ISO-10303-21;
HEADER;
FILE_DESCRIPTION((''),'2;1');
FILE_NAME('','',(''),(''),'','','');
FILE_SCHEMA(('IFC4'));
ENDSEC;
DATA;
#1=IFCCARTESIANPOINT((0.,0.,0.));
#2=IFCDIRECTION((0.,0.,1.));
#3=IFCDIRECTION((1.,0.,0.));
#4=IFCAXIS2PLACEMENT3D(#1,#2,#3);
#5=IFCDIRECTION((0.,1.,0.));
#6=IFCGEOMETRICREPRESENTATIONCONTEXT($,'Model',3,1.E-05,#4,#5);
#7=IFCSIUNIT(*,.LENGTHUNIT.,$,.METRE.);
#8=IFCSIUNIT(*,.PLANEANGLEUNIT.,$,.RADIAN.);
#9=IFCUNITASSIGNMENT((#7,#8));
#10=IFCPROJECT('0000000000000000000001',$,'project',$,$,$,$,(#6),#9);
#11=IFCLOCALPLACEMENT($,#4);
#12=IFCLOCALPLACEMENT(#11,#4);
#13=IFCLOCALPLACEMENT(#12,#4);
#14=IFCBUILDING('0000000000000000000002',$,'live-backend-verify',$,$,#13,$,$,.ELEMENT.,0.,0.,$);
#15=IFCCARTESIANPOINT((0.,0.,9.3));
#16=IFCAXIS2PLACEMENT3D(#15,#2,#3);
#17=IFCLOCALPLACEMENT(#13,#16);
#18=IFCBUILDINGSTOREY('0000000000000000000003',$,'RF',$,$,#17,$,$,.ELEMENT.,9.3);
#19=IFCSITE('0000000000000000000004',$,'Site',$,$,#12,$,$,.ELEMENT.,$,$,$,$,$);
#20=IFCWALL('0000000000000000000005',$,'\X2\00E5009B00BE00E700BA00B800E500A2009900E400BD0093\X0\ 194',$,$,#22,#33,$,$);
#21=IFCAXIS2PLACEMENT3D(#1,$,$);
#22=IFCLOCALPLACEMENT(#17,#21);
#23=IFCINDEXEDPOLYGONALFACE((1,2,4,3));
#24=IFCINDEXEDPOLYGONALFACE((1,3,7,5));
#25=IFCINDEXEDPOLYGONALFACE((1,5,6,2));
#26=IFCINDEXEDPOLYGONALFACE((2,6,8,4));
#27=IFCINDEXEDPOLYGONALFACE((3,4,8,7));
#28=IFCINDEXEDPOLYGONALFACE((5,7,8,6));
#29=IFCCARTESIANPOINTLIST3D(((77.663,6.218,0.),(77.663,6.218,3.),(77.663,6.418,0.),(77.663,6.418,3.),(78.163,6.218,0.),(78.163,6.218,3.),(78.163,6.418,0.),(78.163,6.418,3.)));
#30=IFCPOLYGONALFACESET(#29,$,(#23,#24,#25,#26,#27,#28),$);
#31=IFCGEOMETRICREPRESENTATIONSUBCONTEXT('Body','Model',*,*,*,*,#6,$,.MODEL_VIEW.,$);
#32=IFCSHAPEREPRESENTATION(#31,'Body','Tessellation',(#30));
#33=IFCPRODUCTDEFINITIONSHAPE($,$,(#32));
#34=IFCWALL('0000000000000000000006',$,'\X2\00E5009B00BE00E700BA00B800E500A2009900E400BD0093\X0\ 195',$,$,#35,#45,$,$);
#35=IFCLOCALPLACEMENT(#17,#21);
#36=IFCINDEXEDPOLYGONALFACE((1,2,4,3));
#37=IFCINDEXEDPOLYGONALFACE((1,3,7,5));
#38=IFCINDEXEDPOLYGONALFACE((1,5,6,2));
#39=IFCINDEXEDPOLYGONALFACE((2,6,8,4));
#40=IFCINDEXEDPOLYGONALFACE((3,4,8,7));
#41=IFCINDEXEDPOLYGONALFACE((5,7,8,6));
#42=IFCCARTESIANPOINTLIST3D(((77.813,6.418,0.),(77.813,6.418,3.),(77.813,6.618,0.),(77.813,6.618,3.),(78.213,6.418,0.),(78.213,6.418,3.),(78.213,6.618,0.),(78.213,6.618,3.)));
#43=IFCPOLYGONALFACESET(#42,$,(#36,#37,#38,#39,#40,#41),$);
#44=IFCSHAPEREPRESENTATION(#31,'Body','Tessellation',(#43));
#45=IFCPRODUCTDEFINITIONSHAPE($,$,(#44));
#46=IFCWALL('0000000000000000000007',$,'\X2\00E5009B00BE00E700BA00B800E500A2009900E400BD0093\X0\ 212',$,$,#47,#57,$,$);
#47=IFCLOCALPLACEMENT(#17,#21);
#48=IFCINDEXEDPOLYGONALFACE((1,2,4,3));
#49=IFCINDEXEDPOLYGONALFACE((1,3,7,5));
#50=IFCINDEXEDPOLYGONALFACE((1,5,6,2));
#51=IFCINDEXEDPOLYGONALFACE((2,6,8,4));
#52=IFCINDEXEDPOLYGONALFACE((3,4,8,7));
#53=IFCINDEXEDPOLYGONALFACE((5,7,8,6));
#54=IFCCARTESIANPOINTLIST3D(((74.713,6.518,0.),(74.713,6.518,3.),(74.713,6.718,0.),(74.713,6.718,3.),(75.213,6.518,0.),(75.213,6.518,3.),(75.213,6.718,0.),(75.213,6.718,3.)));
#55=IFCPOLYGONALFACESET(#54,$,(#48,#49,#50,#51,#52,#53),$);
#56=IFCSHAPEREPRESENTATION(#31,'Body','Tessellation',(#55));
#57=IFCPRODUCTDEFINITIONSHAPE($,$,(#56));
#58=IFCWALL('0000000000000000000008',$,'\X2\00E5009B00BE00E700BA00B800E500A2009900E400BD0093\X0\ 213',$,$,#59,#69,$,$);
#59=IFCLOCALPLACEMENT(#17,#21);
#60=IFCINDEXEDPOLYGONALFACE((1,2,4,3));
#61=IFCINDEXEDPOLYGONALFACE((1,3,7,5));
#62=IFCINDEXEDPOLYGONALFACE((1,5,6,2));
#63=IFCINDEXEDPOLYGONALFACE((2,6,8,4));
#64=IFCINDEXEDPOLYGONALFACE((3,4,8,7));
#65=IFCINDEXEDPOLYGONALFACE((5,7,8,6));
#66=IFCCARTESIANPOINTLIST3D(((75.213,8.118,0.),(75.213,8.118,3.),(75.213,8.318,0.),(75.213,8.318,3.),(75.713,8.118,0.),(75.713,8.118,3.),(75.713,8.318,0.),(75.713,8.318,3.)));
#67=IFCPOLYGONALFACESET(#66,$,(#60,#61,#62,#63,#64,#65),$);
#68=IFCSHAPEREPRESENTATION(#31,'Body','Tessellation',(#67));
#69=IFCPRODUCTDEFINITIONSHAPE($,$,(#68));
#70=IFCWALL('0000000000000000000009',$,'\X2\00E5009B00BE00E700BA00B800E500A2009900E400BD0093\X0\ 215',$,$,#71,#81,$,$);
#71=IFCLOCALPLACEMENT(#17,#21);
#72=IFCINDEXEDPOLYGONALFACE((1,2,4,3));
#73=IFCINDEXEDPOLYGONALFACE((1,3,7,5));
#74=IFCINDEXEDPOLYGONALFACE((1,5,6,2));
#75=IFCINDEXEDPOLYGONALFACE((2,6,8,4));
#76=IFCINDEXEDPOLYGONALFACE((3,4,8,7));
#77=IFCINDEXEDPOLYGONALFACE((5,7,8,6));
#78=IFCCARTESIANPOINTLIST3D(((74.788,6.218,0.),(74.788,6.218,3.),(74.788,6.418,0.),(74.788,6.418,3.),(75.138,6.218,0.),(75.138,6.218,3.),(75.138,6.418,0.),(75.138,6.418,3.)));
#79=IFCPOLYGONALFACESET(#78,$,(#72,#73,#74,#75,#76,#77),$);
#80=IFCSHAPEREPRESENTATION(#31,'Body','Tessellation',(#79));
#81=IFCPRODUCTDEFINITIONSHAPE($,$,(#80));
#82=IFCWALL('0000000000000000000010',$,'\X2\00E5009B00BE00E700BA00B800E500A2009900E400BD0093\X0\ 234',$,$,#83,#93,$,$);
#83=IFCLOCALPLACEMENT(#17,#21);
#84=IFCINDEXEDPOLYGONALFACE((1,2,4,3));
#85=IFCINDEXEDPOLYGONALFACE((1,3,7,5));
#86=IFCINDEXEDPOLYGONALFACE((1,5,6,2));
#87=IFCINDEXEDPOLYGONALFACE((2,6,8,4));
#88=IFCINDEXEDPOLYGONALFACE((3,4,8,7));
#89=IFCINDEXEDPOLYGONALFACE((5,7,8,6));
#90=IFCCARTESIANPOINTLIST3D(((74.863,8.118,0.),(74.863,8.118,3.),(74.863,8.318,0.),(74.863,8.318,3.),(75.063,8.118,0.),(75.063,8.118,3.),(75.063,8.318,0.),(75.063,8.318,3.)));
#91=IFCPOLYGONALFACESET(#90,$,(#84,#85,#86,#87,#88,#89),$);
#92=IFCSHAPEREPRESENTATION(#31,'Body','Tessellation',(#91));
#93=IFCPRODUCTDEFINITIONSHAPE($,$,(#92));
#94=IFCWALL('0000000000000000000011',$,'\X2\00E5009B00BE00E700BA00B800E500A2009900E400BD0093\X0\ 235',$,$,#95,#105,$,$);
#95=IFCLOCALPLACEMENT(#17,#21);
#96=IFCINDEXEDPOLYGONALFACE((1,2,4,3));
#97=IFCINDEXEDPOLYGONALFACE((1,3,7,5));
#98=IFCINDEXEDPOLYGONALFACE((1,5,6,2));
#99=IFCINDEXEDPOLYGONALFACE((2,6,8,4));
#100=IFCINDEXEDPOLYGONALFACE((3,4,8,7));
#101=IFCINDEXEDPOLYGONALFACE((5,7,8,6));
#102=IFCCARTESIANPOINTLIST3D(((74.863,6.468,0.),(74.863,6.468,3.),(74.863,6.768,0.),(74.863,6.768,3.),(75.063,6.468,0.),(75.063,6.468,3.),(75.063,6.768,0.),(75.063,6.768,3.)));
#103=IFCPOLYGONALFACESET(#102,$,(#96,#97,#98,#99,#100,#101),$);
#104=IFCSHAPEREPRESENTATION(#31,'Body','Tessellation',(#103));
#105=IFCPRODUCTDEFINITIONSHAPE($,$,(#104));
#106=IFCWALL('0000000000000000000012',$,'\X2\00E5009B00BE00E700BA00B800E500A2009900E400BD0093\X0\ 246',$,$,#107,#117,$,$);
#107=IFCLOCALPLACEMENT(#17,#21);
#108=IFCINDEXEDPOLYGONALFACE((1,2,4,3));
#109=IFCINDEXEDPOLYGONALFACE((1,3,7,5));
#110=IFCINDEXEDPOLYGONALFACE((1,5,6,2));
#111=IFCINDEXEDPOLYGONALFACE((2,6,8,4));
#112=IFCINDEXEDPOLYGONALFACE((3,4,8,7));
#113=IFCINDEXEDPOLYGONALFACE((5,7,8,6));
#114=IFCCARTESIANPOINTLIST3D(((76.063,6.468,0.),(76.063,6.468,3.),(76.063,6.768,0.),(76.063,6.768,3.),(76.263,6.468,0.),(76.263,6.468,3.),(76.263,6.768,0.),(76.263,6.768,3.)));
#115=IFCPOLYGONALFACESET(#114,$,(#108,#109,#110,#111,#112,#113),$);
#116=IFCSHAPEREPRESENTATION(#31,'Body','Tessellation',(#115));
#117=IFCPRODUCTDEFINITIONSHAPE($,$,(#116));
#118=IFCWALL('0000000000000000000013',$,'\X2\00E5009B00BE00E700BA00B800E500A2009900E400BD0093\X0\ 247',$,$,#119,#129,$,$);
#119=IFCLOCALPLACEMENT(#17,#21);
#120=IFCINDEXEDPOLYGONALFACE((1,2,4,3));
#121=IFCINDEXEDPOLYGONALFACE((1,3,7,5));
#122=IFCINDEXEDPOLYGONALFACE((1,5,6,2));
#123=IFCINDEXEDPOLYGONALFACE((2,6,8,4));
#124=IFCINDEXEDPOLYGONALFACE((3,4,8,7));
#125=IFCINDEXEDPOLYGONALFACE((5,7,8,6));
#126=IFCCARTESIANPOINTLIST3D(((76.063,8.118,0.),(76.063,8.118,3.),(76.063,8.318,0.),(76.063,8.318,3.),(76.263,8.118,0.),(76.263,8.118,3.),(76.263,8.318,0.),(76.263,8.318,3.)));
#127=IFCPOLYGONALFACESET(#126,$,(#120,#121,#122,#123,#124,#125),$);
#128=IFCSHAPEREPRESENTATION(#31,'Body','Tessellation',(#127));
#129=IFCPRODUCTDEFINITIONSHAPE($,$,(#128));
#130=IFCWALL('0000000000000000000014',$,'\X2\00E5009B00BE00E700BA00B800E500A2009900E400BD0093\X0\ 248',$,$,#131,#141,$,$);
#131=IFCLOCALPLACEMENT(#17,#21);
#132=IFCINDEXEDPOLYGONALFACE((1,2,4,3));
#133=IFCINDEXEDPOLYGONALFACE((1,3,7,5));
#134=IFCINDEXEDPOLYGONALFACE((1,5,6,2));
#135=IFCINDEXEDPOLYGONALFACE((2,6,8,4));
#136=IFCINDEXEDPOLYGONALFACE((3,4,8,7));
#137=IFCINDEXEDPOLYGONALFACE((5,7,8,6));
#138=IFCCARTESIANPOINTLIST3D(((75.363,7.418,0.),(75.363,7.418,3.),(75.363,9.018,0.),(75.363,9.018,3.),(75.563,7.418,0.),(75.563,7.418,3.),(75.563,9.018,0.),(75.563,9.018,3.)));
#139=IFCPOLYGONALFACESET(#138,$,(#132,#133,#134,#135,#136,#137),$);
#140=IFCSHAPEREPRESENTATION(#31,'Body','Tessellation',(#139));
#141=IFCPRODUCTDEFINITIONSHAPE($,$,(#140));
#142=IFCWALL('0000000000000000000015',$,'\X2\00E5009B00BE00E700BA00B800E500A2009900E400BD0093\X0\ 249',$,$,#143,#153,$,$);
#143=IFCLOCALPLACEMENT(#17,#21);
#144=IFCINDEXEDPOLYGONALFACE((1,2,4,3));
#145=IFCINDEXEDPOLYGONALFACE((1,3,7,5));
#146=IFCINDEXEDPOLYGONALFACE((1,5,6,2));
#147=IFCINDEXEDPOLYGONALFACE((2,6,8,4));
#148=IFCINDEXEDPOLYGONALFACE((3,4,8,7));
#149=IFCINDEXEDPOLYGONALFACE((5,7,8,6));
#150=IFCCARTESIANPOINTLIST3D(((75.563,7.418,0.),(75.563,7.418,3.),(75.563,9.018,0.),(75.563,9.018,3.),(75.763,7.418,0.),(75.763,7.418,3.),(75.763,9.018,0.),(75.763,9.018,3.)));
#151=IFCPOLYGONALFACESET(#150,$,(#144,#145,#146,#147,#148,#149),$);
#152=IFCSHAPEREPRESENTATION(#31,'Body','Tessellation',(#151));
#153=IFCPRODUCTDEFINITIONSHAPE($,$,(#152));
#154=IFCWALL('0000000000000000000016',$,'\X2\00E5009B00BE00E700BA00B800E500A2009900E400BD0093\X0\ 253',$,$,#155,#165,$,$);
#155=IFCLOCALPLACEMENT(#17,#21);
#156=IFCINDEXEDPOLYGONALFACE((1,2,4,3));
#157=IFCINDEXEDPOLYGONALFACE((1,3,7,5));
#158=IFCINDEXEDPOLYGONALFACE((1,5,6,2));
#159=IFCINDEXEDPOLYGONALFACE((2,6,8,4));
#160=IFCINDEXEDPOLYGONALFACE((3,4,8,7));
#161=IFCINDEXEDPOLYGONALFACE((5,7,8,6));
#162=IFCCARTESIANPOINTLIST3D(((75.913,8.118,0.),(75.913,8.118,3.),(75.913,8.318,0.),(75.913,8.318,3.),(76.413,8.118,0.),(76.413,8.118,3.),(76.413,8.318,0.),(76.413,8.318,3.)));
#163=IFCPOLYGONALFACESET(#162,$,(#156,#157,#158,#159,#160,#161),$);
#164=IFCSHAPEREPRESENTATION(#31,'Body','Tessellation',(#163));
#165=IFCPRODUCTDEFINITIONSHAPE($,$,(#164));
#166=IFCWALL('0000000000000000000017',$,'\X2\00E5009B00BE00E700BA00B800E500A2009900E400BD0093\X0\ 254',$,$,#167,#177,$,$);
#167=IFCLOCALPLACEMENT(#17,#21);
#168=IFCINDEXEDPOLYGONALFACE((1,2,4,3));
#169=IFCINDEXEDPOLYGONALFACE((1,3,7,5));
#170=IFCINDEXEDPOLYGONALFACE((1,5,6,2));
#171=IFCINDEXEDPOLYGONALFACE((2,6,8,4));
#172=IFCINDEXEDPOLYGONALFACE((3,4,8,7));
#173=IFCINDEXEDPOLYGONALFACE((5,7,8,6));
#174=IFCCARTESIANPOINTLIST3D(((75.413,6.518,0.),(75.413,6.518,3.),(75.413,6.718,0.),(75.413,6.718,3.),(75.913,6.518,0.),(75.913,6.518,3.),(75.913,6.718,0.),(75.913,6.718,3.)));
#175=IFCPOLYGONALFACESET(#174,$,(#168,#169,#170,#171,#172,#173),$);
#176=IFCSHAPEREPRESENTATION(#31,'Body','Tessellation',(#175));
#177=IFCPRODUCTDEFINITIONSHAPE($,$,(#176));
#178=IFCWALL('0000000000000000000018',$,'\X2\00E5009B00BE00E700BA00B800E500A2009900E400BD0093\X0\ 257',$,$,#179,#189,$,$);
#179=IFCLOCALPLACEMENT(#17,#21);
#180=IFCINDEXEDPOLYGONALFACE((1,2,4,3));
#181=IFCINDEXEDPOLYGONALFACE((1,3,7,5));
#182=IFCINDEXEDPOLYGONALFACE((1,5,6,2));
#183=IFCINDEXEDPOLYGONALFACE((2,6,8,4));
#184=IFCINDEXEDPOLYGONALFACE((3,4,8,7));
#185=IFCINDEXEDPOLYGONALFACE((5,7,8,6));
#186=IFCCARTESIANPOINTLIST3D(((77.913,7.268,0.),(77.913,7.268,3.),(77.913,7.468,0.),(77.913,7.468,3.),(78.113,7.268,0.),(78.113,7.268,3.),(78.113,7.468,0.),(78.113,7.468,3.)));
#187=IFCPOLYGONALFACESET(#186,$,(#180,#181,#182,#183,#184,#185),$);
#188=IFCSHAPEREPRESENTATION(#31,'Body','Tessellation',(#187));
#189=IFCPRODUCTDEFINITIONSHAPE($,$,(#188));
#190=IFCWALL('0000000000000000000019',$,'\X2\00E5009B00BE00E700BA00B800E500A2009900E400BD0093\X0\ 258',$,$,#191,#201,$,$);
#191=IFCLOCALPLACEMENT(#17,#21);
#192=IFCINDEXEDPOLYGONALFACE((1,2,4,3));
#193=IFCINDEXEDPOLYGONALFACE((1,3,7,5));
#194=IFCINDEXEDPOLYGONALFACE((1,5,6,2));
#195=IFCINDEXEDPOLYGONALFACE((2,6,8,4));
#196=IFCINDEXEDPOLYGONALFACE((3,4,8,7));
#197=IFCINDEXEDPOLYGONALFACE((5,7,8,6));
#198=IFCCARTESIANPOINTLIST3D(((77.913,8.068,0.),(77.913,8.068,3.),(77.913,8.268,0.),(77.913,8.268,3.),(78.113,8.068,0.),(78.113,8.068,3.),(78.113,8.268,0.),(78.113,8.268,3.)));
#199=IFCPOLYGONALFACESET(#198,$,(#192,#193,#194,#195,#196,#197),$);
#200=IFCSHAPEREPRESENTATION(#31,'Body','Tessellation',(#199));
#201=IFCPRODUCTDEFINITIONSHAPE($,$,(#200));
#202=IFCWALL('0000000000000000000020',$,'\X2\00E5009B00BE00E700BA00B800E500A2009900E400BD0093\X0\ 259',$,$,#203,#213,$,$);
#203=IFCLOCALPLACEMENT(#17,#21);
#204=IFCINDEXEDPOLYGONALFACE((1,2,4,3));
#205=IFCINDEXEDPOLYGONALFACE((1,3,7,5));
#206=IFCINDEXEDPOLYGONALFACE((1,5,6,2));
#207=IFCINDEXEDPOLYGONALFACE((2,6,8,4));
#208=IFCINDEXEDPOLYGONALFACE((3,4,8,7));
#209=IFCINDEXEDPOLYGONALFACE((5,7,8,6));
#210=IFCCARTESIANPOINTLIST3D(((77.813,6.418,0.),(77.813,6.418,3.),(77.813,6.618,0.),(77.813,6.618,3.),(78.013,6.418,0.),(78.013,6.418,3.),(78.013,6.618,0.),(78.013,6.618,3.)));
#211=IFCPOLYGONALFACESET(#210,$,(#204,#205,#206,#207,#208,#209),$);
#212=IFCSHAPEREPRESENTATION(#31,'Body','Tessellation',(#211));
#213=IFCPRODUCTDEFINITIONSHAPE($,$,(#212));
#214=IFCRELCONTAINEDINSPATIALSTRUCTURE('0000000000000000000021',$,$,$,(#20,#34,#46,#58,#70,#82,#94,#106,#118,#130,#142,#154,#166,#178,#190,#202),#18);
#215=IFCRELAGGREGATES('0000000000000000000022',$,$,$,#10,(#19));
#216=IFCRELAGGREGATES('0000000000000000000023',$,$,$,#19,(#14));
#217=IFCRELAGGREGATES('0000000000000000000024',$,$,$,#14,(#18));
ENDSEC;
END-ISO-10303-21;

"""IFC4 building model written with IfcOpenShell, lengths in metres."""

from ifc_helpers import new_model, si_unit, direction, frame, frame_2d, origin_with_axes, place, context, subcontext, project, spatial, rectangle, extrude, element, save


model = new_model("IFC4")

# Units and contexts
model_context = context("Model", 3, precision=1e-05, world=origin_with_axes(), true_north=direction((0.0, 1.0, 0.0)))
body_context = subcontext(model_context, "Body", "Model", "MODEL_VIEW")
ifc_project = project(units=[si_unit("LENGTHUNIT", "METRE"), si_unit("PLANEANGLEUNIT", "RADIAN")], contexts=[model_context])

# Site, building, storey
placement = place(None, origin_with_axes())
site_placement = place(placement, origin_with_axes())
site = spatial("IfcSite", under=ifc_project, at=site_placement, Name="Site", CompositionType="ELEMENT")
building_placement = place(site_placement, origin_with_axes())
building = spatial("IfcBuilding", under=site, at=building_placement, Name="live-backend-verify", CompositionType="ELEMENT", ElevationOfRefHeight=0.0, ElevationOfTerrain=0.0)
storey_placement = place(building_placement, frame((0.0, 0.0, 9.3), z_axis=(0.0, 0.0, 1.0), x_axis=(1.0, 0.0, 0.0)))
storey = spatial("IfcBuildingStorey", under=building, at=storey_placement, Name="RF", CompositionType="ELEMENT", Elevation=9.3)

# Walls
wall_1_placement = place(storey_placement, frame((77.913, 6.318, 0.0), z_axis=(0.0, 0.0, 1.0), x_axis=(1.0, 0.0, 0.0)))
element("IfcWall", 1, at=wall_1_placement, inside=storey, Name="å\u009b¾çº¸å¢\u0099ä½\u0093 194", context=body_context, shape_type="SweptSolid", body=[
    extrude(rectangle(XDim=0.5, YDim=0.2, at=frame_2d((0.0, 0.0), x_axis=(1.0, 0.0, 0.0))), frame((0.0, 0.0, 0.0), z_axis=(0.0, 0.0, 1.0)), (0.0, 0.0, 1.0), 3.0),
])
wall_2_placement = place(storey_placement, frame((78.013, 6.518, 0.0), z_axis=(0.0, 0.0, 1.0), x_axis=(1.0, 0.0, 0.0)))
element("IfcWall", 2, at=wall_2_placement, inside=storey, Name="å\u009b¾çº¸å¢\u0099ä½\u0093 195", context=body_context, shape_type="SweptSolid", body=[
    extrude(rectangle(XDim=0.4, YDim=0.2, at=frame_2d((0.0, 0.0), x_axis=(1.0, 0.0, 0.0))), frame((0.0, 0.0, 0.0), z_axis=(0.0, 0.0, 1.0)), (0.0, 0.0, 1.0), 3.0),
])
for number, where, z_axis, x_axis, name in (
    (3, (74.963, 6.618, 0.0), (0.0, 0.0, 1.0), (1.0, 0.0, 0.0), "å\u009b¾çº¸å¢\u0099ä½\u0093 212"),
    (4, (75.463, 8.218, 0.0), (0.0, 0.0, 1.0), (-1.0, 0.0, 0.0), "å\u009b¾çº¸å¢\u0099ä½\u0093 213"),
):
    element("IfcWall", number, at=place(storey_placement, frame(where, z_axis=z_axis, x_axis=x_axis)), inside=storey, Name=name, context=body_context, shape_type="SweptSolid", body=[
        extrude(rectangle(XDim=0.5, YDim=0.2, at=frame_2d((0.0, 0.0), x_axis=(1.0, 0.0, 0.0))), frame((0.0, 0.0, 0.0), z_axis=(0.0, 0.0, 1.0)), (0.0, 0.0, 1.0), 3.0),
    ])
wall_3_placement = place(storey_placement, frame((74.963, 6.318, 0.0), z_axis=(0.0, 0.0, 1.0), x_axis=(1.0, 0.0, 0.0)))
element("IfcWall", 5, at=wall_3_placement, inside=storey, Name="å\u009b¾çº¸å¢\u0099ä½\u0093 215", context=body_context, shape_type="SweptSolid", body=[
    extrude(rectangle(XDim=0.35, YDim=0.2, at=frame_2d((0.0, 0.0), x_axis=(1.0, 0.0, 0.0))), frame((0.0, 0.0, 0.0), z_axis=(0.0, 0.0, 1.0)), (0.0, 0.0, 1.0), 3.0),
])
wall_4_placement = place(storey_placement, frame((74.963, 8.218, 0.0), z_axis=(0.0, 0.0, 1.0), x_axis=(0.0, 1.0, 0.0)))
element("IfcWall", 6, at=wall_4_placement, inside=storey, Name="å\u009b¾çº¸å¢\u0099ä½\u0093 234", context=body_context, shape_type="SweptSolid", body=[
    extrude(rectangle(XDim=0.2, YDim=0.2, at=frame_2d((0.0, 0.0), x_axis=(1.0, 0.0, 0.0))), frame((0.0, 0.0, 0.0), z_axis=(0.0, 0.0, 1.0)), (0.0, 0.0, 1.0), 3.0),
])
for number, where, z_axis, x_axis, name in (
    (7, (74.963, 6.618, 0.0), (0.0, 0.0, 1.0), (0.0, -1.0, 0.0), "å\u009b¾çº¸å¢\u0099ä½\u0093 235"),
    (8, (76.163, 6.618, 0.0), (0.0, 0.0, 1.0), (0.0, -1.0, 0.0), "å\u009b¾çº¸å¢\u0099ä½\u0093 246"),
):
    element("IfcWall", number, at=place(storey_placement, frame(where, z_axis=z_axis, x_axis=x_axis)), inside=storey, Name=name, context=body_context, shape_type="SweptSolid", body=[
        extrude(rectangle(XDim=0.3, YDim=0.2, at=frame_2d((0.0, 0.0), x_axis=(1.0, 0.0, 0.0))), frame((0.0, 0.0, 0.0), z_axis=(0.0, 0.0, 1.0)), (0.0, 0.0, 1.0), 3.0),
    ])
wall_5_placement = place(storey_placement, frame((76.163, 8.218, 0.0), z_axis=(0.0, 0.0, 1.0), x_axis=(0.0, 1.0, 0.0)))
element("IfcWall", 9, at=wall_5_placement, inside=storey, Name="å\u009b¾çº¸å¢\u0099ä½\u0093 247", context=body_context, shape_type="SweptSolid", body=[
    extrude(rectangle(XDim=0.2, YDim=0.2, at=frame_2d((0.0, 0.0), x_axis=(1.0, 0.0, 0.0))), frame((0.0, 0.0, 0.0), z_axis=(0.0, 0.0, 1.0)), (0.0, 0.0, 1.0), 3.0),
])
for number, where, z_axis, x_axis, name in (
    (10, (75.463, 8.218, 0.0), (0.0, 0.0, 1.0), (0.0, -1.0, 0.0), "å\u009b¾çº¸å¢\u0099ä½\u0093 248"),
    (11, (75.663, 8.218, 0.0), (0.0, 0.0, 1.0), (0.0, -1.0, 0.0), "å\u009b¾çº¸å¢\u0099ä½\u0093 249"),
):
    element("IfcWall", number, at=place(storey_placement, frame(where, z_axis=z_axis, x_axis=x_axis)), inside=storey, Name=name, context=body_context, shape_type="SweptSolid", body=[
        extrude(rectangle(XDim=1.6, YDim=0.2, at=frame_2d((0.0, 0.0), x_axis=(1.0, 0.0, 0.0))), frame((0.0, 0.0, 0.0), z_axis=(0.0, 0.0, 1.0)), (0.0, 0.0, 1.0), 3.0),
    ])
for number, where, z_axis, x_axis, name in (
    (12, (76.163, 8.218, 0.0), (0.0, 0.0, 1.0), (-1.0, 0.0, 0.0), "å\u009b¾çº¸å¢\u0099ä½\u0093 253"),
    (13, (75.663, 6.618, 0.0), (0.0, 0.0, 1.0), (1.0, 0.0, 0.0), "å\u009b¾çº¸å¢\u0099ä½\u0093 254"),
):
    element("IfcWall", number, at=place(storey_placement, frame(where, z_axis=z_axis, x_axis=x_axis)), inside=storey, Name=name, context=body_context, shape_type="SweptSolid", body=[
        extrude(rectangle(XDim=0.5, YDim=0.2, at=frame_2d((0.0, 0.0), x_axis=(1.0, 0.0, 0.0))), frame((0.0, 0.0, 0.0), z_axis=(0.0, 0.0, 1.0)), (0.0, 0.0, 1.0), 3.0),
    ])
for number, where, z_axis, x_axis, name in (
    (14, (78.013, 7.368, 0.0), (0.0, 0.0, 1.0), (-1.0, 0.0, 0.0), "å\u009b¾çº¸å¢\u0099ä½\u0093 257"),
    (15, (78.013, 8.168, 0.0), (0.0, 0.0, 1.0), (-1.0, 0.0, 0.0), "å\u009b¾çº¸å¢\u0099ä½\u0093 258"),
    (16, (77.913, 6.518, 0.0), (0.0, 0.0, 1.0), (0.0, -1.0, 0.0), "å\u009b¾çº¸å¢\u0099ä½\u0093 259"),
):
    element("IfcWall", number, at=place(storey_placement, frame(where, z_axis=z_axis, x_axis=x_axis)), inside=storey, Name=name, context=body_context, shape_type="SweptSolid", body=[
        extrude(rectangle(XDim=0.2, YDim=0.2, at=frame_2d((0.0, 0.0), x_axis=(1.0, 0.0, 0.0))), frame((0.0, 0.0, 0.0), z_axis=(0.0, 0.0, 1.0)), (0.0, 0.0, 1.0), 3.0),
    ])

save(model, "model.ifc")
